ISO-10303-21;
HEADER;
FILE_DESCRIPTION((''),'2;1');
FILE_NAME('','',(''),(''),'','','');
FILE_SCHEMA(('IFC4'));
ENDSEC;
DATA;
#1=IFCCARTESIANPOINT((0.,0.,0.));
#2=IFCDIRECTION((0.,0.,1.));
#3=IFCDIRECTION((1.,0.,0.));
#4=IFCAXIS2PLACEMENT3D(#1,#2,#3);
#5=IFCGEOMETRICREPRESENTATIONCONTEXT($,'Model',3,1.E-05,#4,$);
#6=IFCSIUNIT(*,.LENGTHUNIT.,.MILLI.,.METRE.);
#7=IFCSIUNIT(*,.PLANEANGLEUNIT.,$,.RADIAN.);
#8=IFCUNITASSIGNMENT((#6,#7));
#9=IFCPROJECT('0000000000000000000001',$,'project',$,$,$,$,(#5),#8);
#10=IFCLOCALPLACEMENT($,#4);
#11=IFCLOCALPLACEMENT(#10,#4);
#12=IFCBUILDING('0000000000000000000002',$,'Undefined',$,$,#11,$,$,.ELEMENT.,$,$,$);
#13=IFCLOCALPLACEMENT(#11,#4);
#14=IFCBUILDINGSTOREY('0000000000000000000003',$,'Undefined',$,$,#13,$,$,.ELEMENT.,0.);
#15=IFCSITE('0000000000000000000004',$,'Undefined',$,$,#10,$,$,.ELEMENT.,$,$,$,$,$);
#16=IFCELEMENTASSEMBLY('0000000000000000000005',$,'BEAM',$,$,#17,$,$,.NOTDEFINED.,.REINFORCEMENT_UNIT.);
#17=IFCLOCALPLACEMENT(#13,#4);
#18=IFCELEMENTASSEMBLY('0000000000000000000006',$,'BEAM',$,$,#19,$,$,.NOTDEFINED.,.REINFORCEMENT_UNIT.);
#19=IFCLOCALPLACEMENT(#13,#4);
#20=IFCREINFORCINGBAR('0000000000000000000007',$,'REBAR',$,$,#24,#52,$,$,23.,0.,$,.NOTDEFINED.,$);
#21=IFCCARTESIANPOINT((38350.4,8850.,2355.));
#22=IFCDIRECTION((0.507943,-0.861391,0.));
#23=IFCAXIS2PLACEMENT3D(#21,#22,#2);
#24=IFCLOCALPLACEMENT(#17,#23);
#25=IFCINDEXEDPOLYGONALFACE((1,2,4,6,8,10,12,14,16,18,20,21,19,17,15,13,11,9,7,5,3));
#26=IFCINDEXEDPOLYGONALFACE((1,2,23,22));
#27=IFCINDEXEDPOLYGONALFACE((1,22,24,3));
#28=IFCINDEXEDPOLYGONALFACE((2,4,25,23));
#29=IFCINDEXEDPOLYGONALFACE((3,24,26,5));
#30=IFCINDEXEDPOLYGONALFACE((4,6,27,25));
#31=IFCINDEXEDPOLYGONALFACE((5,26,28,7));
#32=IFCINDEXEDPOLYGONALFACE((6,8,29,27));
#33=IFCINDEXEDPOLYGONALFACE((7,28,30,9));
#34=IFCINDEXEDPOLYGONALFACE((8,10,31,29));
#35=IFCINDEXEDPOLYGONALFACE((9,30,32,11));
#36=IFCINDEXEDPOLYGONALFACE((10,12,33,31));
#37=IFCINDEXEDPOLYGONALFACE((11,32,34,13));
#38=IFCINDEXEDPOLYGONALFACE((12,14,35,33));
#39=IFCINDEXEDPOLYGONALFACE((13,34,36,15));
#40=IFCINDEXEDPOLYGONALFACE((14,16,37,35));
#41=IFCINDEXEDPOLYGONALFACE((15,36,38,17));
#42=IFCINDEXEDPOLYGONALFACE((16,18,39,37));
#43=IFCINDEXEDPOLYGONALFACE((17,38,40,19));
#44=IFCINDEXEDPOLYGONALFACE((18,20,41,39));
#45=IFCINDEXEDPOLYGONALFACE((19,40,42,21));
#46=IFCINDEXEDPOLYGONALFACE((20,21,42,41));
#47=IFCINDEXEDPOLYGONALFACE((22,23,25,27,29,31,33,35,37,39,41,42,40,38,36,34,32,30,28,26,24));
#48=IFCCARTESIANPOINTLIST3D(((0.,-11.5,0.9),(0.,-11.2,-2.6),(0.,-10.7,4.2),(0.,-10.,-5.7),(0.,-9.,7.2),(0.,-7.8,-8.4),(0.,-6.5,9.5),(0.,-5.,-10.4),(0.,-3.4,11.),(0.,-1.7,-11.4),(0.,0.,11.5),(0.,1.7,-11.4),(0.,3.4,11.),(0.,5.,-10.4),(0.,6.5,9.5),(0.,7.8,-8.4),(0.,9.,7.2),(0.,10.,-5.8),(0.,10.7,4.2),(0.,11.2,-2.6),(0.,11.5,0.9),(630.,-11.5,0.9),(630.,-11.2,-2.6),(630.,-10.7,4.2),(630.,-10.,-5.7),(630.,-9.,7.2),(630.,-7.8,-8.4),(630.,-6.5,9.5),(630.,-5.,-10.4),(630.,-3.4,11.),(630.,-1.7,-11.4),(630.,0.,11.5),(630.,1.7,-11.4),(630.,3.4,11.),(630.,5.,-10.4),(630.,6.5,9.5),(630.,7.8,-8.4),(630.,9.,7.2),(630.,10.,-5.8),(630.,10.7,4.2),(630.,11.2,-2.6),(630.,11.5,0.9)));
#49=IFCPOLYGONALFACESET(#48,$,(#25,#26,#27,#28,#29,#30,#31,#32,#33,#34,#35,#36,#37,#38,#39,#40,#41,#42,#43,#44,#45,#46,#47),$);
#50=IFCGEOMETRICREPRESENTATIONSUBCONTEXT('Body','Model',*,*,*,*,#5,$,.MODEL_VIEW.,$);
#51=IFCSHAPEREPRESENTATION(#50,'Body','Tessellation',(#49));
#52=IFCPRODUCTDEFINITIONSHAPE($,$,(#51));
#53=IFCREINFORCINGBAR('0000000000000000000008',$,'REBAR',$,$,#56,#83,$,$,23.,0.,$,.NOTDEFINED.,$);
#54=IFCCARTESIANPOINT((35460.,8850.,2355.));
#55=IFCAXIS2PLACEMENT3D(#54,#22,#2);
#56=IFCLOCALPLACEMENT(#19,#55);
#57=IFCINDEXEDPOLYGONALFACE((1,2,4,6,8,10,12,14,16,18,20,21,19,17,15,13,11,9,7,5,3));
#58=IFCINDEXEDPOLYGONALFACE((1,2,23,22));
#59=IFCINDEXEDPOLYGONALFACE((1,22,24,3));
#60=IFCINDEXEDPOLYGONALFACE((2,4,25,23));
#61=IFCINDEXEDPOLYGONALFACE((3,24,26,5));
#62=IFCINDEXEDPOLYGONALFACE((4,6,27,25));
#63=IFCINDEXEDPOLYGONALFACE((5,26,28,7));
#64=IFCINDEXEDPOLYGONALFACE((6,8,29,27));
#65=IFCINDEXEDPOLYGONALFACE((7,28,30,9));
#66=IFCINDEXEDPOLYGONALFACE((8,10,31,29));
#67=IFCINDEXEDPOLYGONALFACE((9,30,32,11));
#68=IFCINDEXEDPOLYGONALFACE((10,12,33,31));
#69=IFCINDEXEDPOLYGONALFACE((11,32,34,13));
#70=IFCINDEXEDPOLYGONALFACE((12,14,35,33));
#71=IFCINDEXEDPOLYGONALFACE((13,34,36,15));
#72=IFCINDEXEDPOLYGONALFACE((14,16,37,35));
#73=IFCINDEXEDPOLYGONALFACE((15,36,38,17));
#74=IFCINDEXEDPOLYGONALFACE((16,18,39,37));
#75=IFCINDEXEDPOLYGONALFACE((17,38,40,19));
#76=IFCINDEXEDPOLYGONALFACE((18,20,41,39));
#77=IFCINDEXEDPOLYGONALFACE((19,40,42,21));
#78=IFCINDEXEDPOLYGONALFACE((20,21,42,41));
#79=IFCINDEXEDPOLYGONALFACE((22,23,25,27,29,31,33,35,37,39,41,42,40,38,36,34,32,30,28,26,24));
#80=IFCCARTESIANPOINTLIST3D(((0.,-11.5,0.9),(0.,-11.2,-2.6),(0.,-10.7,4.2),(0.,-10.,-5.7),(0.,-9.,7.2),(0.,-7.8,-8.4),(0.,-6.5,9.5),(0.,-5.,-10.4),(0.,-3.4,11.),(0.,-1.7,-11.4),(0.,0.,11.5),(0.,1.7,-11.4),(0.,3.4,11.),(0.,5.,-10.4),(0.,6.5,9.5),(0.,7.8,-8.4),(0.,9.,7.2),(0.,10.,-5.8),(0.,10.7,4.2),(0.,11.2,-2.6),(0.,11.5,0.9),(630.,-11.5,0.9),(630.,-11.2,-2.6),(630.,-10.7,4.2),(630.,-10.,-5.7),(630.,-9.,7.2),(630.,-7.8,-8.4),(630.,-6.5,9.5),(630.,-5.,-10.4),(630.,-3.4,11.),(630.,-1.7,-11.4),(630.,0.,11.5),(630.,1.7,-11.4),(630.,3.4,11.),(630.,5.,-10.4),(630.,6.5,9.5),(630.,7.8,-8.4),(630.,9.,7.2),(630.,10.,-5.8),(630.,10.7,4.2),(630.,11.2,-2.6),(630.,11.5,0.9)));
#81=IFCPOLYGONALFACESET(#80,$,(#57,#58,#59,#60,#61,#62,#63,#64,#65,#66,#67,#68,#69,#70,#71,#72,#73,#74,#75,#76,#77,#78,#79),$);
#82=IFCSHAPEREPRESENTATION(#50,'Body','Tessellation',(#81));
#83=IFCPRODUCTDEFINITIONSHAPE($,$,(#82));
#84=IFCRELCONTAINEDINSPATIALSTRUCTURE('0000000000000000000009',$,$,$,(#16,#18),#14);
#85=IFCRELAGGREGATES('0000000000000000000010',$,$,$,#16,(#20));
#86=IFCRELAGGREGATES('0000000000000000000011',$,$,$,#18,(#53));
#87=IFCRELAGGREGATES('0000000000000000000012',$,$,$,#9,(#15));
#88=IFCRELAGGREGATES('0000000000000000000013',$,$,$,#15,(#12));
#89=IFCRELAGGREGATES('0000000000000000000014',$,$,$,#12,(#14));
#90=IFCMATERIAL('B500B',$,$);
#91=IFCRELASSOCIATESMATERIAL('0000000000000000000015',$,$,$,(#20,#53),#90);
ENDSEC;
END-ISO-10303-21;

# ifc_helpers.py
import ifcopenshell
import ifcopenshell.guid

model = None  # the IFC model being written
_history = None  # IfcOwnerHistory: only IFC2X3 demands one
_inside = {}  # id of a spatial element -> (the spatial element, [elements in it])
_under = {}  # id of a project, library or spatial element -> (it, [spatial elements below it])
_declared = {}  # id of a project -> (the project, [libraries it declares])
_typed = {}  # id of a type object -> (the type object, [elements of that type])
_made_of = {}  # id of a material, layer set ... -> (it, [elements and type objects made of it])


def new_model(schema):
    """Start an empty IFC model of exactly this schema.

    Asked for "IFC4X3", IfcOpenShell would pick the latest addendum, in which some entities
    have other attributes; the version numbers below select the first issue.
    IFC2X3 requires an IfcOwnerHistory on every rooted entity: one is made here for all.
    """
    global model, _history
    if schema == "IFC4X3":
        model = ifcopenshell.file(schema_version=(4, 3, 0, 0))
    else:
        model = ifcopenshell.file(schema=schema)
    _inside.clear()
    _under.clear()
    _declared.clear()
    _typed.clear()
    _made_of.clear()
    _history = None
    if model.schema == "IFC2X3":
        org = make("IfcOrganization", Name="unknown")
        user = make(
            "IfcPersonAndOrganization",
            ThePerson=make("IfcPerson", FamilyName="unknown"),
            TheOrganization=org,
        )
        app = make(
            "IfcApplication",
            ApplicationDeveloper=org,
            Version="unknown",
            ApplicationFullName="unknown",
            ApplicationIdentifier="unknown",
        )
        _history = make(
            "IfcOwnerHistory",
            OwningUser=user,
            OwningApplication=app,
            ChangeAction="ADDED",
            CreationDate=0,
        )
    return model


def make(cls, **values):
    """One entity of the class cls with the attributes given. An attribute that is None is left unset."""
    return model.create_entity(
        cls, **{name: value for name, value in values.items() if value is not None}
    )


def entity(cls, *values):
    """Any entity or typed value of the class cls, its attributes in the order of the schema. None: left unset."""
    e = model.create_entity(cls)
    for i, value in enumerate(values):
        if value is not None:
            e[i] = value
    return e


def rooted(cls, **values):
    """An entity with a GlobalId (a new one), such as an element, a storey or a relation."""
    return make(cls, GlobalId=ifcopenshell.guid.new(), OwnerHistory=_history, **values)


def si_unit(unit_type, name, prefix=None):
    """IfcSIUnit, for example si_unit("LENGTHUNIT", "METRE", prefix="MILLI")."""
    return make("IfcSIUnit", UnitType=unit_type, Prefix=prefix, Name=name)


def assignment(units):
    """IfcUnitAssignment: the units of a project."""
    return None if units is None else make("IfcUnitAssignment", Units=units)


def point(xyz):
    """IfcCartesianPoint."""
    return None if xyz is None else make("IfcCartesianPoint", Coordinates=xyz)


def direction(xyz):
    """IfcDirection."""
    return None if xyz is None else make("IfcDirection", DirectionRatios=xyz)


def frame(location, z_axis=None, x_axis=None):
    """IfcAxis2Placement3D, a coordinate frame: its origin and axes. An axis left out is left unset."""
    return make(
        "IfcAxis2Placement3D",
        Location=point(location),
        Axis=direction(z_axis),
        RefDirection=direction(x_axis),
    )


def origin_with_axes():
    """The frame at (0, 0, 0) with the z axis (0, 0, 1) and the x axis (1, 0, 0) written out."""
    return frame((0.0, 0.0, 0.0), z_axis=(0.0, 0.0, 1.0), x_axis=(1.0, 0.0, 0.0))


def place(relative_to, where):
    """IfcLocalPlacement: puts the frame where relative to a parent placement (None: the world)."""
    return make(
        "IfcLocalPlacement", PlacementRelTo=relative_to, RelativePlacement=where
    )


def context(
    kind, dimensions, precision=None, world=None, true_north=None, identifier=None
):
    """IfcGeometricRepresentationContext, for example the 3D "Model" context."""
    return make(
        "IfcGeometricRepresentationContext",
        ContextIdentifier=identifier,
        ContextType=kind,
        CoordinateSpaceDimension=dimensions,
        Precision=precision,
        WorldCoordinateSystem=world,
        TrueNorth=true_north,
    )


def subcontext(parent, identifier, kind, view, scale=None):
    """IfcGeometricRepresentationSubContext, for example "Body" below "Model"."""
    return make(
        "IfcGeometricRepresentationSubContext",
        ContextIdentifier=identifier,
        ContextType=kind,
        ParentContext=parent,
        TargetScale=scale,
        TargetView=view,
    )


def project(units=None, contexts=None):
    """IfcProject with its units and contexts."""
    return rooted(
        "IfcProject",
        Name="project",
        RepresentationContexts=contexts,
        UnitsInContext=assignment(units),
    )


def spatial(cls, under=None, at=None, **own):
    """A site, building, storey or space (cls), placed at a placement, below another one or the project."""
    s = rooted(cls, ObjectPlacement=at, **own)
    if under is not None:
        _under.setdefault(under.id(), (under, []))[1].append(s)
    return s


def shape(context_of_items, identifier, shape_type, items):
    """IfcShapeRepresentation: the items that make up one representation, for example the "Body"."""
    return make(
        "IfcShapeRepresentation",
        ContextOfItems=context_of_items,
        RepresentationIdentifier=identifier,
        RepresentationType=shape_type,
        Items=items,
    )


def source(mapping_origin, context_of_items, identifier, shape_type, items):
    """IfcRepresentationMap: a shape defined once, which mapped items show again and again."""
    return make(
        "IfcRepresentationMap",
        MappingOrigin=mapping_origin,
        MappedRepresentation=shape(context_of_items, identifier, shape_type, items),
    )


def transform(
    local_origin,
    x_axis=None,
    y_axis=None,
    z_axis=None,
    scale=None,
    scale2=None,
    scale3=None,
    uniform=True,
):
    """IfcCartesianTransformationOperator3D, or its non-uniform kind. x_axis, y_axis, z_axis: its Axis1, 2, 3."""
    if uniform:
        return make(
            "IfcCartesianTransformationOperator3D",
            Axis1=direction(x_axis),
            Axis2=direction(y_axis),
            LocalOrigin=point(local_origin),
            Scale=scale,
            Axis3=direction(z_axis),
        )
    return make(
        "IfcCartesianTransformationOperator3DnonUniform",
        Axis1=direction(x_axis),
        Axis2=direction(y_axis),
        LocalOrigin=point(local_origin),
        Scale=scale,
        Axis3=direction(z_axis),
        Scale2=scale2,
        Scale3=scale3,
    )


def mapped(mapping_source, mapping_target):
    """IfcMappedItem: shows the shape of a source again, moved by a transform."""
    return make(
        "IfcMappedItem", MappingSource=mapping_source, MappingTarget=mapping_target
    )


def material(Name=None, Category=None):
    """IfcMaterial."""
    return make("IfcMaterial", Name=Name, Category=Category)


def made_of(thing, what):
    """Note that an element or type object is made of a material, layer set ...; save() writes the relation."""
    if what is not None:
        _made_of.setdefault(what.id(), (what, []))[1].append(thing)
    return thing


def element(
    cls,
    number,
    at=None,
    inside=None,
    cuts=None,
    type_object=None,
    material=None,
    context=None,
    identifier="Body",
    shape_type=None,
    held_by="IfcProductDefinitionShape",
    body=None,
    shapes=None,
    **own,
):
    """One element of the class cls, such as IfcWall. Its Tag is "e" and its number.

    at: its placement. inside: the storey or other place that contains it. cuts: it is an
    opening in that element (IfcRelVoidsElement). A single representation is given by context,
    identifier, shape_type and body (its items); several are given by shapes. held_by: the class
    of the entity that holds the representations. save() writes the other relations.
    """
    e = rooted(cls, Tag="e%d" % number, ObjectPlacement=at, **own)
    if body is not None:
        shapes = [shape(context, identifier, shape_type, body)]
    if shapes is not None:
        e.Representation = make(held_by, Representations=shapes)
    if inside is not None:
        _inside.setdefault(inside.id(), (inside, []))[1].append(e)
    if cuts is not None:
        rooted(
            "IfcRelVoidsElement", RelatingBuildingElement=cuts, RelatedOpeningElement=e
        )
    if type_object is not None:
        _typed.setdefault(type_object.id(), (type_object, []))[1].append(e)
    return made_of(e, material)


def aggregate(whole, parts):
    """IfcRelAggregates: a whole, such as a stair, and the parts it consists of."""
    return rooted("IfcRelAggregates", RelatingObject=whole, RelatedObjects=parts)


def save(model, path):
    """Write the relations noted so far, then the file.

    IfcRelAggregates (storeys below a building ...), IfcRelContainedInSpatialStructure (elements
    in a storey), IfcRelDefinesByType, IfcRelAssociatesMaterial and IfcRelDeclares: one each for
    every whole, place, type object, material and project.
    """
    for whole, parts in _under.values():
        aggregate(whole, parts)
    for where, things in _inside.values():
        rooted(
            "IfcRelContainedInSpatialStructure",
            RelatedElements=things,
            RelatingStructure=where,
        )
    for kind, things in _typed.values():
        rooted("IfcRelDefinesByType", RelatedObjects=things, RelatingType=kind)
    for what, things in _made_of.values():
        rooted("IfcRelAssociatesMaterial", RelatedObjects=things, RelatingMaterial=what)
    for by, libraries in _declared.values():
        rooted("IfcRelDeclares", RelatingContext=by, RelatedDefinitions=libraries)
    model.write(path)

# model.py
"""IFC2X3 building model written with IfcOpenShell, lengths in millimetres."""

from ifc_helpers import new_model, entity, si_unit, frame, origin_with_axes, place, context, subcontext, project, spatial, source, transform, mapped, material, element, aggregate, save


model = new_model("IFC2X3")

# Units and contexts
model_context = context("Model", 3, precision=1e-05, world=origin_with_axes())
body_context = subcontext(model_context, "Body", "Model", "MODEL_VIEW")
ifc_project = project(units=[si_unit("LENGTHUNIT", "METRE", prefix="MILLI"), si_unit("PLANEANGLEUNIT", "RADIAN")], contexts=[model_context])

# Site, building, storey
site_placement = place(None, origin_with_axes())
site = spatial("IfcSite", under=ifc_project, at=site_placement, Name="Undefined", CompositionType="ELEMENT")
building_placement = place(site_placement, origin_with_axes())
building = spatial("IfcBuilding", under=site, at=building_placement, Name="Undefined", CompositionType="ELEMENT")
storey_placement = place(building_placement, origin_with_axes())
storey = spatial("IfcBuildingStorey", under=building, at=storey_placement, Name="Undefined", CompositionType="ELEMENT", Elevation=0.0)

# Element assemblies
assembly_1_placement = place(storey_placement, origin_with_axes())
assembly_1 = element("IfcElementAssembly", 1, at=assembly_1_placement, inside=storey, Name="BEAM", AssemblyPlace="NOTDEFINED", PredefinedType="REINFORCEMENT_UNIT")
assembly_2_placement = place(storey_placement, origin_with_axes())
assembly_2 = element("IfcElementAssembly", 2, at=assembly_2_placement, inside=storey, Name="BEAM", AssemblyPlace="NOTDEFINED", PredefinedType="REINFORCEMENT_UNIT")

# Shared definitions
ifc_material_1 = material(Name="B500B")

# Reinforcing bars
shared_shape_1 = source(origin_with_axes(), body_context, "Body", "AdvancedSweptSolid", [
    entity("IfcSweptDiskSolid", entity("IfcTrimmedCurve", entity("IfcLine", entity("IfcCartesianPoint", [0.0, 0.0, 0.0]), entity("IfcVector", entity("IfcDirection", [1.0, 0.0, 0.0]), 1.0)), [entity("IfcParameterValue", 0.0)], [entity("IfcParameterValue", 630.0)], True, "PARAMETER"), 11.5, None, 0.0, 630.0),
])
reinforcing_bar_1_placement = place(assembly_1_placement, frame((38350.4, 8850.0, 2355.0), z_axis=(0.507943, -0.861391, 0.0), x_axis=(0.0, 0.0, 1.0)))
reinforcing_bar_1 = element("IfcReinforcingBar", 3, at=reinforcing_bar_1_placement, material=ifc_material_1, Name="REBAR", BarRole="NOTDEFINED", CrossSectionArea=0.0, NominalDiameter=23.0, context=body_context, shape_type="MappedRepresentation", body=[
    mapped(shared_shape_1, transform((0.0, 0.0, 0.0))),
])
aggregate(assembly_1, [reinforcing_bar_1])
shared_shape_2 = source(origin_with_axes(), body_context, "Body", "AdvancedSweptSolid", [
    entity("IfcSweptDiskSolid", entity("IfcTrimmedCurve", entity("IfcLine", entity("IfcCartesianPoint", [0.0, 0.0, 0.0]), entity("IfcVector", entity("IfcDirection", [1.0, 0.0, 0.0]), 1.0)), [entity("IfcParameterValue", 0.0)], [entity("IfcParameterValue", 630.0)], True, "PARAMETER"), 11.5, None, 0.0, 630.0),
])
reinforcing_bar_2_placement = place(assembly_2_placement, frame((35460.0, 8850.0, 2355.0), z_axis=(0.507943, -0.861391, 0.0), x_axis=(0.0, 0.0, 1.0)))
reinforcing_bar_2 = element("IfcReinforcingBar", 4, at=reinforcing_bar_2_placement, material=ifc_material_1, Name="REBAR", BarRole="NOTDEFINED", CrossSectionArea=0.0, NominalDiameter=23.0, context=body_context, shape_type="MappedRepresentation", body=[
    mapped(shared_shape_2, transform((0.0, 0.0, 0.0))),
])
aggregate(assembly_2, [reinforcing_bar_2])

save(model, "model.ifc")
